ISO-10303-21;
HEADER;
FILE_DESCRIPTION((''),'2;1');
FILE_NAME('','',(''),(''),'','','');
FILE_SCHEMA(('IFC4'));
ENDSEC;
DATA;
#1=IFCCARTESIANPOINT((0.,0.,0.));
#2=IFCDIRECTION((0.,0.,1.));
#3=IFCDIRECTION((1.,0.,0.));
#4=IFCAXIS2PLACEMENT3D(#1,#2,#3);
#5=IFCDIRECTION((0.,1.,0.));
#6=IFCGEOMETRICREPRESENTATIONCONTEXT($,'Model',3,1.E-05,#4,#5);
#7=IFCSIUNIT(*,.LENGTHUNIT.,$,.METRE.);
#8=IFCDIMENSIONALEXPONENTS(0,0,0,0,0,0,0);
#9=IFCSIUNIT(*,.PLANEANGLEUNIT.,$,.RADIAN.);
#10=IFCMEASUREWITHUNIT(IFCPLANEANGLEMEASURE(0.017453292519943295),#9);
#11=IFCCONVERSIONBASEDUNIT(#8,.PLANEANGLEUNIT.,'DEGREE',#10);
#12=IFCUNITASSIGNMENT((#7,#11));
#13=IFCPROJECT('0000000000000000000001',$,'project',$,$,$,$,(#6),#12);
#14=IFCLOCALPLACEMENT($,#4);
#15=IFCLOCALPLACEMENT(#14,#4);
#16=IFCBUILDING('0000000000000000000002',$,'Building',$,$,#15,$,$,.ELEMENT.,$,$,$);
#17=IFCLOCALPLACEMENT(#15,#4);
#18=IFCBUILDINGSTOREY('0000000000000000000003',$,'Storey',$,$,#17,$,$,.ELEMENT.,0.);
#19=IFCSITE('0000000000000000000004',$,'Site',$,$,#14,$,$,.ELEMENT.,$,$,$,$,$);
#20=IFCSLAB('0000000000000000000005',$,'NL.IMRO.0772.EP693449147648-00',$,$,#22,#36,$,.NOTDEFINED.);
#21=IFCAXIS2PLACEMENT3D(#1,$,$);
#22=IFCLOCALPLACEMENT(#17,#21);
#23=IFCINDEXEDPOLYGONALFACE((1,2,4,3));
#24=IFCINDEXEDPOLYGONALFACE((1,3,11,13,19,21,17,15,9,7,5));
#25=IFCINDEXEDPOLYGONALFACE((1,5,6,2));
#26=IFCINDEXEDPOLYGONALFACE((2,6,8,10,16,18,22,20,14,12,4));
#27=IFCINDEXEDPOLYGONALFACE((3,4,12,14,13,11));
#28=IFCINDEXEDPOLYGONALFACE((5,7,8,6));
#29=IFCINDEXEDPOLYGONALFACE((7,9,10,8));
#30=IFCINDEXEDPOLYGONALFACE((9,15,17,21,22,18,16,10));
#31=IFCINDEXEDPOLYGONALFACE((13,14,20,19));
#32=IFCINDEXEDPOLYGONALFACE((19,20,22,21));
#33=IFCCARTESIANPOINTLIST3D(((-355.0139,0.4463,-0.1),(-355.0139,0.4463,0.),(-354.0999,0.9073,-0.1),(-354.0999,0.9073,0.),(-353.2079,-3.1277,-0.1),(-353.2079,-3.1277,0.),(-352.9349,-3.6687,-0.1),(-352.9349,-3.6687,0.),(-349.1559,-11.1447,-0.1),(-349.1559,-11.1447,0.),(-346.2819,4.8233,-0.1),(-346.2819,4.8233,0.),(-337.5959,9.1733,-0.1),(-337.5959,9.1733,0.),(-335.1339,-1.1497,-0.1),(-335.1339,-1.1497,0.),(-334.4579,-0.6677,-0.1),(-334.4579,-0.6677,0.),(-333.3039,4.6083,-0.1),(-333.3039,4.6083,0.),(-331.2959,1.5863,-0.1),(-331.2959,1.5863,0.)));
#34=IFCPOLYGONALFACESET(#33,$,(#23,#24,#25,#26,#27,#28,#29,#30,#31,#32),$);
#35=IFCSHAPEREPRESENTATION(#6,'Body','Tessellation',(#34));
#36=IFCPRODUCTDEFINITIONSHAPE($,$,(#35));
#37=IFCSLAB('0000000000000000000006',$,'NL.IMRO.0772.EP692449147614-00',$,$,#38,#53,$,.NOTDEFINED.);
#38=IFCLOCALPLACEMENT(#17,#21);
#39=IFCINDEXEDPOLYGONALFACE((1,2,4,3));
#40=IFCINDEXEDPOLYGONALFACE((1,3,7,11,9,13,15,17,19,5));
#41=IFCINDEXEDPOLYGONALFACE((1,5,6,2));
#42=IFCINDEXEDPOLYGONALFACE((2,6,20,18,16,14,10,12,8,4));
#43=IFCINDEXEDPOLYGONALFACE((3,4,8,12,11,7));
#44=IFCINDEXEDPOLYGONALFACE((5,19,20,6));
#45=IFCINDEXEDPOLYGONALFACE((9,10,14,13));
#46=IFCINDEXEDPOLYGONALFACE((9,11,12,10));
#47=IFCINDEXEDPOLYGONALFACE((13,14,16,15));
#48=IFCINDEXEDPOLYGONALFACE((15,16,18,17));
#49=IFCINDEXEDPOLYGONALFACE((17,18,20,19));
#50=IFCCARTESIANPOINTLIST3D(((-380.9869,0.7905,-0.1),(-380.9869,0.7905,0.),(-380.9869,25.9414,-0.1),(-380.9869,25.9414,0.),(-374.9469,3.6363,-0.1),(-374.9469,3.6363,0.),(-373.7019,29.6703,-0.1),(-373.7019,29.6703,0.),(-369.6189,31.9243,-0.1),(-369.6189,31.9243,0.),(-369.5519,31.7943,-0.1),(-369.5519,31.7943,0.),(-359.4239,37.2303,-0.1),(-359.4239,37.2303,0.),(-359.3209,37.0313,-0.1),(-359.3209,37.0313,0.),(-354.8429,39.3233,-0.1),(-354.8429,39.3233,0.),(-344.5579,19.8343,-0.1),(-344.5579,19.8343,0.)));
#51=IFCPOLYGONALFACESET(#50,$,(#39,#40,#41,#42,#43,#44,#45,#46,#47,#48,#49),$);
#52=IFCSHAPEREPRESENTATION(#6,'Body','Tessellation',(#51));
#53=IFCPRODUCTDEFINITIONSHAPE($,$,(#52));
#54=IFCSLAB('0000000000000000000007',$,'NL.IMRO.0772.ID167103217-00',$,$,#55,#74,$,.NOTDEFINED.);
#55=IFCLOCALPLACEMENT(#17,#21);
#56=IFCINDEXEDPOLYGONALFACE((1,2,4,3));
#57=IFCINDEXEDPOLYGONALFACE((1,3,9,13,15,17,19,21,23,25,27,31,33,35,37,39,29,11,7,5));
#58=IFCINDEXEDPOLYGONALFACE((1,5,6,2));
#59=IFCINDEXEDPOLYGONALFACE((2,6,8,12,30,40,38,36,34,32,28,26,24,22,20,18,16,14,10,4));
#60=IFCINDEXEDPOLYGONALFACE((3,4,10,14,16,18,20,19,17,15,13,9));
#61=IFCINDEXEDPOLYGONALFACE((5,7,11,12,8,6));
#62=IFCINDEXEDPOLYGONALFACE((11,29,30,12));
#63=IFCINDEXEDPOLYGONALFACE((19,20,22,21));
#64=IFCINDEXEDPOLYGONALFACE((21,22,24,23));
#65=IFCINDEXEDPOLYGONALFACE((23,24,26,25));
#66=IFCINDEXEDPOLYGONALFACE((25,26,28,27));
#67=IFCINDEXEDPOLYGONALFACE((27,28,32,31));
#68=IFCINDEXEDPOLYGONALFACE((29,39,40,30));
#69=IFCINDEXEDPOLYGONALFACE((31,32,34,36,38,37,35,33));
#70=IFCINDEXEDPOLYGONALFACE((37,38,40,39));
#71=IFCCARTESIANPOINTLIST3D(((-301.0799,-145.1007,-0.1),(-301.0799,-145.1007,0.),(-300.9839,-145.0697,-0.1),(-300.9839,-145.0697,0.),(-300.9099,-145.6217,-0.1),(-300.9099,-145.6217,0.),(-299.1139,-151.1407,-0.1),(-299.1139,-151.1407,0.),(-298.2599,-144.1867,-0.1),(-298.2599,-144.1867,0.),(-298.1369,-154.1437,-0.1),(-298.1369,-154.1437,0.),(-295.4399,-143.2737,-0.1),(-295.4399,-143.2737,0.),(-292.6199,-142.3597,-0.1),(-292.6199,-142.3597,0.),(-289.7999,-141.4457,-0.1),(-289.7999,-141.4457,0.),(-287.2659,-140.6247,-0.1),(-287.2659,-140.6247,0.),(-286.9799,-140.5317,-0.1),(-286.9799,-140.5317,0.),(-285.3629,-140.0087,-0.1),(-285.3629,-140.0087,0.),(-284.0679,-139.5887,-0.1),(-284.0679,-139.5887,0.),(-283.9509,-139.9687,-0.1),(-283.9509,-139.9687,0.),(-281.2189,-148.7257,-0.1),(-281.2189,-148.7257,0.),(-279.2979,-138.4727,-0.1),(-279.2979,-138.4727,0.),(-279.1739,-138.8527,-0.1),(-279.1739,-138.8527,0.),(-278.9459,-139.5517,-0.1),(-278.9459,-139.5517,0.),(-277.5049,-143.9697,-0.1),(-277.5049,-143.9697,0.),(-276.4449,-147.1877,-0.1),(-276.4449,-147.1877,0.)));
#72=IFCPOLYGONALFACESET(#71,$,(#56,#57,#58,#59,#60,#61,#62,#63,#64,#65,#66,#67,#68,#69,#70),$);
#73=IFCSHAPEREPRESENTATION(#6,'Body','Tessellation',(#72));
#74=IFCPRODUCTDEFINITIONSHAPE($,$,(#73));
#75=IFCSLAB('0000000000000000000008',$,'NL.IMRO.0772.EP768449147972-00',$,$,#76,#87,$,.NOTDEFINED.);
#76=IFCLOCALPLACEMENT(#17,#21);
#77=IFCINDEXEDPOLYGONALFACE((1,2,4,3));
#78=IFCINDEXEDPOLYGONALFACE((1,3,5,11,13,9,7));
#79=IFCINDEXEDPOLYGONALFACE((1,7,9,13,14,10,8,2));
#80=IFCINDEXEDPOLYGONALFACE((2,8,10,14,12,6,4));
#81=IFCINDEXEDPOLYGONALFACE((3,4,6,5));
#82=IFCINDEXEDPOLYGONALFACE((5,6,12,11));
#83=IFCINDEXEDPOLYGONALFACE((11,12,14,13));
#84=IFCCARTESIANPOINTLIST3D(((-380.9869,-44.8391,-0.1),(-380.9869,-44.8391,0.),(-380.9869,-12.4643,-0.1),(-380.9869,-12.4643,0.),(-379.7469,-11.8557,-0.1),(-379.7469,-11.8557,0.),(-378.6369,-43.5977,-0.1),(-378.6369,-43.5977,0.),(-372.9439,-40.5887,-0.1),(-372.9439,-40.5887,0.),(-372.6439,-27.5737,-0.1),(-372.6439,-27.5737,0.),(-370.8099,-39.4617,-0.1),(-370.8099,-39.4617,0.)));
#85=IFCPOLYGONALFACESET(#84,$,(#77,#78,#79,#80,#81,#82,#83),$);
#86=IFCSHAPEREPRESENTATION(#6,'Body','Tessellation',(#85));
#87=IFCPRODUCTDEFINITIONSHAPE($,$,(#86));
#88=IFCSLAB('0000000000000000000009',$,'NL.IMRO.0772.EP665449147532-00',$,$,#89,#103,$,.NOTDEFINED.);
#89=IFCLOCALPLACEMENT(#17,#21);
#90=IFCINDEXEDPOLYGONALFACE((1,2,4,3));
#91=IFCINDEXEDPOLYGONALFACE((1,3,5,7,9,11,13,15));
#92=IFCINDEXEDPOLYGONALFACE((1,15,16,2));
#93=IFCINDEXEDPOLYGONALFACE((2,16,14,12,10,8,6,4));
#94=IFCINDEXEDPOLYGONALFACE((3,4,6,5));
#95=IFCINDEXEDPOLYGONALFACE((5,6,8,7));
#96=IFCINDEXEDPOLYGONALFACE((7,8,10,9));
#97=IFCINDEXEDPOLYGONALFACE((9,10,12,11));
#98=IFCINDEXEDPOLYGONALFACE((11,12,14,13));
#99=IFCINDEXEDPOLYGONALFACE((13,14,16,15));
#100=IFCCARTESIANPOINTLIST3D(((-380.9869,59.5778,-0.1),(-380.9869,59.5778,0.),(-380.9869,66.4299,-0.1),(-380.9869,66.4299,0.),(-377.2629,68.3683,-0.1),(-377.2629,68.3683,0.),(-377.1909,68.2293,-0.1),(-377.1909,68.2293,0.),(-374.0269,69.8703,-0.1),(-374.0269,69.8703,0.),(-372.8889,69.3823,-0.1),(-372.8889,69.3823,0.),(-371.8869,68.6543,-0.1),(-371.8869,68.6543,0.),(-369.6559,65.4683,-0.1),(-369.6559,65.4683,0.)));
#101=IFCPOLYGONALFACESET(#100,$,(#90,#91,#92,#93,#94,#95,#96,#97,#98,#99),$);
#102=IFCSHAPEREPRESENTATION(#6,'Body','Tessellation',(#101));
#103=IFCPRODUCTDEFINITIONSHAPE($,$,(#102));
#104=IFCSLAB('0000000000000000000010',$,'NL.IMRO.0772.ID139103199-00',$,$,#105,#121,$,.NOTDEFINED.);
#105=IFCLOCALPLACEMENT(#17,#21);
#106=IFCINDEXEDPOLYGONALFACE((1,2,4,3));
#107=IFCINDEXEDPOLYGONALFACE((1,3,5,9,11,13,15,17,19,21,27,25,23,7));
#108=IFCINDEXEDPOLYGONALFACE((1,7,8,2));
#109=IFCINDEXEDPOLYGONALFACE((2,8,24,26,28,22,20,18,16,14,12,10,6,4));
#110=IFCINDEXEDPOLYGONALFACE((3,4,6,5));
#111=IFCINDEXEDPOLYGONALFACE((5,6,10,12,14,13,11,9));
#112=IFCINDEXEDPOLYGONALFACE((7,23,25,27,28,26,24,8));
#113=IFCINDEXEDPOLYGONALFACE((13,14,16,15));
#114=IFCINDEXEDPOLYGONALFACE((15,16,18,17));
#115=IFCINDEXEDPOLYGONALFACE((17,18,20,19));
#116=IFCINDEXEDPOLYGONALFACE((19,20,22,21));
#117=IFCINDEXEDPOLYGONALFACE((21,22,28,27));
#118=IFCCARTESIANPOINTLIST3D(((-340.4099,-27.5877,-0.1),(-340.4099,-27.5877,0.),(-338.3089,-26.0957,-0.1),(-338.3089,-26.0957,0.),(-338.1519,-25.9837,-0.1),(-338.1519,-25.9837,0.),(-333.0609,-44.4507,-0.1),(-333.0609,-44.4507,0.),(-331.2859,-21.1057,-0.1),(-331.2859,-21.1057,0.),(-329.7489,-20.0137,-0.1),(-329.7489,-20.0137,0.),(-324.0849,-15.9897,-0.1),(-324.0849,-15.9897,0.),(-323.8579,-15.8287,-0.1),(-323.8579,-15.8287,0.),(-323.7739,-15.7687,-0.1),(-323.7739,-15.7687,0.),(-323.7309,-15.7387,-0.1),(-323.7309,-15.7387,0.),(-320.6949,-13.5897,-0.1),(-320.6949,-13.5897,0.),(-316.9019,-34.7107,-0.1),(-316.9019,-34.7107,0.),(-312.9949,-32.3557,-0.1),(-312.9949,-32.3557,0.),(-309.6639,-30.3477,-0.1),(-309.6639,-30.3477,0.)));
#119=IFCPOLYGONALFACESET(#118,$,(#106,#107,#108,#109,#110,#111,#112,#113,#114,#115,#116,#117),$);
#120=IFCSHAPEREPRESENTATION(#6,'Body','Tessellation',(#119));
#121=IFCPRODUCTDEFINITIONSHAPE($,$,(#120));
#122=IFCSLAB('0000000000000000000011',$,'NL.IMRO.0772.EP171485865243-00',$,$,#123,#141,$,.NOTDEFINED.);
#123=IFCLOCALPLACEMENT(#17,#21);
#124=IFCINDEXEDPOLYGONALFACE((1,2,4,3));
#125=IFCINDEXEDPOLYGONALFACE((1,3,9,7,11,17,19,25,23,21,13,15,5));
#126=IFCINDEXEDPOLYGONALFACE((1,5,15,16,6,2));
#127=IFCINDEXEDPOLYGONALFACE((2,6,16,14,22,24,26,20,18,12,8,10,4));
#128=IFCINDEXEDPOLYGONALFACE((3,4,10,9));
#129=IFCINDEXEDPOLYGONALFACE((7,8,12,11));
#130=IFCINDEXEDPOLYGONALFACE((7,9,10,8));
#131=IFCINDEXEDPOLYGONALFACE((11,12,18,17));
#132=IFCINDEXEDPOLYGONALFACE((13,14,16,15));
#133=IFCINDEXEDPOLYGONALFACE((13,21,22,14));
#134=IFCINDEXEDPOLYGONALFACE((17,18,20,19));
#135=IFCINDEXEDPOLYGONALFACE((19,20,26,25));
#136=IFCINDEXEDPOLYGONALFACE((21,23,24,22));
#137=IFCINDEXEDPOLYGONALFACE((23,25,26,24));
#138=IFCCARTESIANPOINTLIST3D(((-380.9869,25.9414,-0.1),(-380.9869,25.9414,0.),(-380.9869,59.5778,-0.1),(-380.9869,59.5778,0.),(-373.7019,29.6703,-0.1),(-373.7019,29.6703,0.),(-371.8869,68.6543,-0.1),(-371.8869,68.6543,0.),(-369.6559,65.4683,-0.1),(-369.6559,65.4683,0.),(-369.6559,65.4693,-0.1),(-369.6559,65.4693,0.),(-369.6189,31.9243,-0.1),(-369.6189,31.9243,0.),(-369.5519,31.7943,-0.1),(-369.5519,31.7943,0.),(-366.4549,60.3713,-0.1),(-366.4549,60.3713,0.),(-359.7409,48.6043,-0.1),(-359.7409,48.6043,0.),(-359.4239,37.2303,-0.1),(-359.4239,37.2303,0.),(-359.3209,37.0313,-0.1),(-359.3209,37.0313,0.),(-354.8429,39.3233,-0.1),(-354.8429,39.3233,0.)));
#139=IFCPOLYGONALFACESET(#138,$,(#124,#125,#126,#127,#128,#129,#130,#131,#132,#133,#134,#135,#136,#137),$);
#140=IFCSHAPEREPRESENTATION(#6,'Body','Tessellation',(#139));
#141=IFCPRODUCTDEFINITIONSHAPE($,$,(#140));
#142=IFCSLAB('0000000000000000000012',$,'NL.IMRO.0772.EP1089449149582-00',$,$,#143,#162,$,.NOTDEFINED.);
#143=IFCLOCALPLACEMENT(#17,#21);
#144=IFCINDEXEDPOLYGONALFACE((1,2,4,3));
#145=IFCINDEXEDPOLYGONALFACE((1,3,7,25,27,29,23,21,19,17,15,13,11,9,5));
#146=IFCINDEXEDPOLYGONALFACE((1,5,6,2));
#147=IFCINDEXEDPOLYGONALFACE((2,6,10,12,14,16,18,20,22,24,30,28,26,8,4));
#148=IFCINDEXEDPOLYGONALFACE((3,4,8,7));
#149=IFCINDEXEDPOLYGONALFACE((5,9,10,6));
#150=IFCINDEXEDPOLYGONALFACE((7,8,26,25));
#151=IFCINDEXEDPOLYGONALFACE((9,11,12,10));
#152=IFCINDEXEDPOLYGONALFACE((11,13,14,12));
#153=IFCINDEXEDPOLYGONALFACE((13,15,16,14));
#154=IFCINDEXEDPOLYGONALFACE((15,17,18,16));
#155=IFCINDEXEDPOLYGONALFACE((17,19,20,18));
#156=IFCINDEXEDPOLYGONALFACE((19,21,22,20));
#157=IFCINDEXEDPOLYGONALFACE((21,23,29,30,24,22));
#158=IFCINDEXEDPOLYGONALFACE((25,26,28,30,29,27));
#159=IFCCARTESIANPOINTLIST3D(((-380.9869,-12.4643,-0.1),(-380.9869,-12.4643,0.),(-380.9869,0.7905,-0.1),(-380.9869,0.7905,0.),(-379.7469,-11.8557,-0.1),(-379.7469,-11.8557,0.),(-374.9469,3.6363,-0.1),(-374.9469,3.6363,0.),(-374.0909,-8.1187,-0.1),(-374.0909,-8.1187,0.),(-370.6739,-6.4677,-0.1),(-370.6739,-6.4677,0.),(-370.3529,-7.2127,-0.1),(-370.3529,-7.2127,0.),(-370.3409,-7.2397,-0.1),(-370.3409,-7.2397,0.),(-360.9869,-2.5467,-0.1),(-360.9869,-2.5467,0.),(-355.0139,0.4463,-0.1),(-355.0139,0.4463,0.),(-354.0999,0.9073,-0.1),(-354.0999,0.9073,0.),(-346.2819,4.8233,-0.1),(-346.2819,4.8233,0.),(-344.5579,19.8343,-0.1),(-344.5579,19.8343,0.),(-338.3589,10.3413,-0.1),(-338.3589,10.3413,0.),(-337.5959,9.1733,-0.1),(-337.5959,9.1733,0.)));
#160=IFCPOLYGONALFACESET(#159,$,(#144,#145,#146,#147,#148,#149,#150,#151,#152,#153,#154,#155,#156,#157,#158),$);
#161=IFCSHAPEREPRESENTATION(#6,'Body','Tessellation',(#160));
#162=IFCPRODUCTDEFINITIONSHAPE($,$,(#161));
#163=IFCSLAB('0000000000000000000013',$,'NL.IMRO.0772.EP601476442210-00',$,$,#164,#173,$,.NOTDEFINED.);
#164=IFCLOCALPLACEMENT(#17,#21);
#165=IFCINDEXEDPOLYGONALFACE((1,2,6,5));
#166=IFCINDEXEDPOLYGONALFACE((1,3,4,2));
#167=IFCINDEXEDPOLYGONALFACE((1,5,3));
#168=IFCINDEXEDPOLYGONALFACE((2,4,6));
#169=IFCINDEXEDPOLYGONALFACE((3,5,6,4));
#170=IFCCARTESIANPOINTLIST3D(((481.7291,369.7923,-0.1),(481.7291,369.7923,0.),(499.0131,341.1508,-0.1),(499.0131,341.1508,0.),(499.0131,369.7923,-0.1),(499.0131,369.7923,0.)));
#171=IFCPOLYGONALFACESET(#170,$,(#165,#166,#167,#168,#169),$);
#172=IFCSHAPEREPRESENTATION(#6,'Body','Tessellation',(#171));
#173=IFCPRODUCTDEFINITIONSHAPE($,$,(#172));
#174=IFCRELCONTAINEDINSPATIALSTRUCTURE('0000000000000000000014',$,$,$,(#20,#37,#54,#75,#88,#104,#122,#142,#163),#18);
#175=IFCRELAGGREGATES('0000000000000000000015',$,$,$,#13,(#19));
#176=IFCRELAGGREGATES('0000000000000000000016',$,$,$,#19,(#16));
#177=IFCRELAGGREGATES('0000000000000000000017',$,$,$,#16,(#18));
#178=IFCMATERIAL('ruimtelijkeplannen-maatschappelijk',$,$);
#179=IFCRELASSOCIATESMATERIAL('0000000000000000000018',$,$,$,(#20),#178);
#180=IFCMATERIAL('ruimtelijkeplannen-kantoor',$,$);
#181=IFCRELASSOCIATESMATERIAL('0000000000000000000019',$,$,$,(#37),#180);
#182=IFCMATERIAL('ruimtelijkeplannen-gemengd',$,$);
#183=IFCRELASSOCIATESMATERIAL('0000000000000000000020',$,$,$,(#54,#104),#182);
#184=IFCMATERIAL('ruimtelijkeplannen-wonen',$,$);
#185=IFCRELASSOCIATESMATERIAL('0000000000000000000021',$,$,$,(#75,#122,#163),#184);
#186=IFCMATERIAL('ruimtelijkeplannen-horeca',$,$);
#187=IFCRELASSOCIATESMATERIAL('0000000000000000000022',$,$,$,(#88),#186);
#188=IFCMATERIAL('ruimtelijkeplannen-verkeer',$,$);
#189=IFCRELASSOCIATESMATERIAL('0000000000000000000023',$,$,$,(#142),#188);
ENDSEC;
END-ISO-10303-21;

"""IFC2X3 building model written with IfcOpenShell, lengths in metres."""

from ifc_helpers import new_model, entity, si_unit, converted_unit, direction, frame, origin_with_axes, place, context, project, spatial, polyline, outline, extrude, material, element, save


model = new_model("IFC2X3")

# Units and contexts
model_context = context("Model", 3, precision=1e-05, world=origin_with_axes(), true_north=direction((0.0, 1.0, 0.0)))
ifc_project = project(units=[si_unit("LENGTHUNIT", "METRE"), converted_unit("PLANEANGLEUNIT", "DEGREE", entity("IfcPlaneAngleMeasure", 0.017453292519943295), si_unit("PLANEANGLEUNIT", "RADIAN"), dimensions=[0, 0, 0, 0, 0, 0, 0])], contexts=[model_context])

# Site, building, storey
site_placement = place(None, origin_with_axes())
site = spatial("IfcSite", under=ifc_project, at=site_placement, Name="Site", CompositionType="ELEMENT")
building_placement = place(site_placement, origin_with_axes())
building = spatial("IfcBuilding", under=site, at=building_placement, Name="Building", CompositionType="ELEMENT")
storey_placement = place(building_placement, origin_with_axes())
storey = spatial("IfcBuildingStorey", under=building, at=storey_placement, Name="Storey", CompositionType="ELEMENT", Elevation=0.0)

# Slabs
ifc_material_1 = material(Name="ruimtelijkeplannen-wonen")
ifc_material_2 = material(Name="ruimtelijkeplannen-maatschappelijk")
slab_1_placement = place(storey_placement, frame((0.0, 0.0, -0.1), z_axis=(0.0, 0.0, 1.0), x_axis=(1.0, 0.0, 0.0)))
element("IfcSlab", 1, at=slab_1_placement, inside=storey, material=ifc_material_2, Name="NL.IMRO.0772.EP693449147648-00", PredefinedType="NOTDEFINED", context=model_context, shape_type="SweptSolid", body=[
    extrude(outline(polyline([(-334.4579, -0.6677), (-335.1339, -1.1497), (-349.1559, -11.1447), (-352.9349, -3.6687), (-353.2079, -3.1277), (-355.0139, 0.4463), (-354.0999, 0.9073), (-346.2819, 4.8233), (-337.5959, 9.1733), (-333.3039, 4.6083), (-331.2959, 1.5863), (-334.4579, -0.6677)])), origin_with_axes(), (0.0, 0.0, 1.0), 0.1),
])
ifc_material_3 = material(Name="ruimtelijkeplannen-kantoor")
slab_2_placement = place(storey_placement, frame((0.0, 0.0, -0.1), z_axis=(0.0, 0.0, 1.0), x_axis=(1.0, 0.0, 0.0)))
element("IfcSlab", 2, at=slab_2_placement, inside=storey, material=ifc_material_3, Name="NL.IMRO.0772.EP692449147614-00", PredefinedType="NOTDEFINED", context=model_context, shape_type="SweptSolid", body=[
    extrude(outline(polyline([(-373.7019, 29.6703), (-369.5519, 31.7943), (-369.6189, 31.9243), (-359.4239, 37.2303), (-359.3209, 37.0313), (-354.8429, 39.3233), (-344.5579, 19.8343), (-374.9469, 3.6363), (-380.9869, 0.7905), (-380.9869, 25.9414), (-373.7019, 29.6703)])), origin_with_axes(), (0.0, 0.0, 1.0), 0.1),
])
ifc_material_4 = material(Name="ruimtelijkeplannen-gemengd")
slab_3_placement = place(storey_placement, frame((0.0, 0.0, -0.1), z_axis=(0.0, 0.0, 1.0), x_axis=(1.0, 0.0, 0.0)))
element("IfcSlab", 3, at=slab_3_placement, inside=storey, material=ifc_material_4, Name="NL.IMRO.0772.ID167103217-00", PredefinedType="NOTDEFINED", context=model_context, shape_type="SweptSolid", body=[
    extrude(outline(polyline([(-295.4399, -143.2737), (-292.6199, -142.3597), (-289.7999, -141.4457), (-287.2659, -140.6247), (-286.9799, -140.5317), (-285.3629, -140.0087), (-284.0679, -139.5887), (-283.9509, -139.9687), (-279.2979, -138.4727), (-279.1739, -138.8527), (-278.9459, -139.5517), (-277.5049, -143.9697), (-276.4449, -147.1877), (-281.2189, -148.7257), (-298.1369, -154.1437), (-299.1139, -151.1407), (-300.9099, -145.6217), (-301.0799, -145.1007), (-300.9839, -145.0697), (-298.2599, -144.1867), (-295.4399, -143.2737)])), origin_with_axes(), (0.0, 0.0, 1.0), 0.1),
])
slab_4_placement = place(storey_placement, frame((0.0, 0.0, -0.1), z_axis=(0.0, 0.0, 1.0), x_axis=(1.0, 0.0, 0.0)))
element("IfcSlab", 4, at=slab_4_placement, inside=storey, material=ifc_material_1, Name="NL.IMRO.0772.EP768449147972-00", PredefinedType="NOTDEFINED", context=model_context, shape_type="SweptSolid", body=[
    extrude(outline(polyline([(-379.7469, -11.8557), (-372.6439, -27.5737), (-370.8099, -39.4617), (-372.9439, -40.5887), (-378.6369, -43.5977), (-380.9869, -44.8391), (-380.9869, -12.4643), (-379.7469, -11.8557)])), origin_with_axes(), (0.0, 0.0, 1.0), 0.1),
])
ifc_material_5 = material(Name="ruimtelijkeplannen-horeca")
slab_5_placement = place(storey_placement, frame((0.0, 0.0, -0.1), z_axis=(0.0, 0.0, 1.0), x_axis=(1.0, 0.0, 0.0)))
element("IfcSlab", 5, at=slab_5_placement, inside=storey, material=ifc_material_5, Name="NL.IMRO.0772.EP665449147532-00", PredefinedType="NOTDEFINED", context=model_context, shape_type="SweptSolid", body=[
    extrude(outline(polyline([(-377.2629, 68.3683), (-377.1909, 68.2293), (-374.0269, 69.8703), (-372.8889, 69.3823), (-371.8869, 68.6543), (-369.6559, 65.4683), (-380.9869, 59.5778), (-380.9869, 66.4299), (-377.2629, 68.3683)])), origin_with_axes(), (0.0, 0.0, 1.0), 0.1),
])
slab_6_placement = place(storey_placement, frame((0.0, 0.0, -0.1), z_axis=(0.0, 0.0, 1.0), x_axis=(1.0, 0.0, 0.0)))
element("IfcSlab", 6, at=slab_6_placement, inside=storey, material=ifc_material_4, Name="NL.IMRO.0772.ID139103199-00", PredefinedType="NOTDEFINED", context=model_context, shape_type="SweptSolid", body=[
    extrude(outline(polyline([(-329.7489, -20.0137), (-324.0849, -15.9897), (-323.8579, -15.8287), (-323.7739, -15.7687), (-323.7309, -15.7387), (-320.6949, -13.5897), (-309.6639, -30.3477), (-312.9949, -32.3557), (-316.9019, -34.7107), (-333.0609, -44.4507), (-340.4099, -27.5877), (-338.3089, -26.0957), (-338.1519, -25.9837), (-331.2859, -21.1057), (-329.7489, -20.0137)])), origin_with_axes(), (0.0, 0.0, 1.0), 0.1),
])
slab_7_placement = place(storey_placement, frame((0.0, 0.0, -0.1), z_axis=(0.0, 0.0, 1.0), x_axis=(1.0, 0.0, 0.0)))
element("IfcSlab", 7, at=slab_7_placement, inside=storey, material=ifc_material_1, Name="NL.IMRO.0772.EP171485865243-00", PredefinedType="NOTDEFINED", context=model_context, shape_type="SweptSolid", body=[
    extrude(outline(polyline([(-369.6559, 65.4683), (-371.8869, 68.6543), (-369.6559, 65.4693), (-366.4549, 60.3713), (-359.7409, 48.6043), (-354.8429, 39.3233), (-359.3209, 37.0313), (-359.4239, 37.2303), (-369.6189, 31.9243), (-369.5519, 31.7943), (-373.7019, 29.6703), (-380.9869, 25.9414), (-380.9869, 59.5778), (-369.6559, 65.4683)])), origin_with_axes(), (0.0, 0.0, 1.0), 0.1),
])
ifc_material_6 = material(Name="ruimtelijkeplannen-verkeer")
slab_8_placement = place(storey_placement, frame((0.0, 0.0, -0.1), z_axis=(0.0, 0.0, 1.0), x_axis=(1.0, 0.0, 0.0)))
element("IfcSlab", 8, at=slab_8_placement, inside=storey, material=ifc_material_6, Name="NL.IMRO.0772.EP1089449149582-00", PredefinedType="NOTDEFINED", context=model_context, shape_type="SweptSolid", body=[
    extrude(outline(polyline([(-374.9469, 3.6363), (-344.5579, 19.8343), (-338.3589, 10.3413), (-337.5959, 9.1733), (-346.2819, 4.8233), (-354.0999, 0.9073), (-355.0139, 0.4463), (-360.9869, -2.5467), (-370.3409, -7.2397), (-370.3529, -7.2127), (-370.6739, -6.4677), (-374.0909, -8.1187), (-379.7469, -11.8557), (-380.9869, -12.4643), (-380.9869, 0.7905), (-374.9469, 3.6363)])), origin_with_axes(), (0.0, 0.0, 1.0), 0.1),
])
slab_9_placement = place(storey_placement, frame((0.0, 0.0, -0.1), z_axis=(0.0, 0.0, 1.0), x_axis=(1.0, 0.0, 0.0)))
element("IfcSlab", 9, at=slab_9_placement, inside=storey, material=ifc_material_1, Name="NL.IMRO.0772.EP601476442210-00", PredefinedType="NOTDEFINED", context=model_context, shape_type="SweptSolid", body=[
    extrude(outline(polyline([(481.7291, 369.7923), (499.0131, 369.7923), (499.0131, 341.1508), (481.7291, 369.7923)])), origin_with_axes(), (0.0, 0.0, 1.0), 0.1),
])

save(model, "model.ifc")
